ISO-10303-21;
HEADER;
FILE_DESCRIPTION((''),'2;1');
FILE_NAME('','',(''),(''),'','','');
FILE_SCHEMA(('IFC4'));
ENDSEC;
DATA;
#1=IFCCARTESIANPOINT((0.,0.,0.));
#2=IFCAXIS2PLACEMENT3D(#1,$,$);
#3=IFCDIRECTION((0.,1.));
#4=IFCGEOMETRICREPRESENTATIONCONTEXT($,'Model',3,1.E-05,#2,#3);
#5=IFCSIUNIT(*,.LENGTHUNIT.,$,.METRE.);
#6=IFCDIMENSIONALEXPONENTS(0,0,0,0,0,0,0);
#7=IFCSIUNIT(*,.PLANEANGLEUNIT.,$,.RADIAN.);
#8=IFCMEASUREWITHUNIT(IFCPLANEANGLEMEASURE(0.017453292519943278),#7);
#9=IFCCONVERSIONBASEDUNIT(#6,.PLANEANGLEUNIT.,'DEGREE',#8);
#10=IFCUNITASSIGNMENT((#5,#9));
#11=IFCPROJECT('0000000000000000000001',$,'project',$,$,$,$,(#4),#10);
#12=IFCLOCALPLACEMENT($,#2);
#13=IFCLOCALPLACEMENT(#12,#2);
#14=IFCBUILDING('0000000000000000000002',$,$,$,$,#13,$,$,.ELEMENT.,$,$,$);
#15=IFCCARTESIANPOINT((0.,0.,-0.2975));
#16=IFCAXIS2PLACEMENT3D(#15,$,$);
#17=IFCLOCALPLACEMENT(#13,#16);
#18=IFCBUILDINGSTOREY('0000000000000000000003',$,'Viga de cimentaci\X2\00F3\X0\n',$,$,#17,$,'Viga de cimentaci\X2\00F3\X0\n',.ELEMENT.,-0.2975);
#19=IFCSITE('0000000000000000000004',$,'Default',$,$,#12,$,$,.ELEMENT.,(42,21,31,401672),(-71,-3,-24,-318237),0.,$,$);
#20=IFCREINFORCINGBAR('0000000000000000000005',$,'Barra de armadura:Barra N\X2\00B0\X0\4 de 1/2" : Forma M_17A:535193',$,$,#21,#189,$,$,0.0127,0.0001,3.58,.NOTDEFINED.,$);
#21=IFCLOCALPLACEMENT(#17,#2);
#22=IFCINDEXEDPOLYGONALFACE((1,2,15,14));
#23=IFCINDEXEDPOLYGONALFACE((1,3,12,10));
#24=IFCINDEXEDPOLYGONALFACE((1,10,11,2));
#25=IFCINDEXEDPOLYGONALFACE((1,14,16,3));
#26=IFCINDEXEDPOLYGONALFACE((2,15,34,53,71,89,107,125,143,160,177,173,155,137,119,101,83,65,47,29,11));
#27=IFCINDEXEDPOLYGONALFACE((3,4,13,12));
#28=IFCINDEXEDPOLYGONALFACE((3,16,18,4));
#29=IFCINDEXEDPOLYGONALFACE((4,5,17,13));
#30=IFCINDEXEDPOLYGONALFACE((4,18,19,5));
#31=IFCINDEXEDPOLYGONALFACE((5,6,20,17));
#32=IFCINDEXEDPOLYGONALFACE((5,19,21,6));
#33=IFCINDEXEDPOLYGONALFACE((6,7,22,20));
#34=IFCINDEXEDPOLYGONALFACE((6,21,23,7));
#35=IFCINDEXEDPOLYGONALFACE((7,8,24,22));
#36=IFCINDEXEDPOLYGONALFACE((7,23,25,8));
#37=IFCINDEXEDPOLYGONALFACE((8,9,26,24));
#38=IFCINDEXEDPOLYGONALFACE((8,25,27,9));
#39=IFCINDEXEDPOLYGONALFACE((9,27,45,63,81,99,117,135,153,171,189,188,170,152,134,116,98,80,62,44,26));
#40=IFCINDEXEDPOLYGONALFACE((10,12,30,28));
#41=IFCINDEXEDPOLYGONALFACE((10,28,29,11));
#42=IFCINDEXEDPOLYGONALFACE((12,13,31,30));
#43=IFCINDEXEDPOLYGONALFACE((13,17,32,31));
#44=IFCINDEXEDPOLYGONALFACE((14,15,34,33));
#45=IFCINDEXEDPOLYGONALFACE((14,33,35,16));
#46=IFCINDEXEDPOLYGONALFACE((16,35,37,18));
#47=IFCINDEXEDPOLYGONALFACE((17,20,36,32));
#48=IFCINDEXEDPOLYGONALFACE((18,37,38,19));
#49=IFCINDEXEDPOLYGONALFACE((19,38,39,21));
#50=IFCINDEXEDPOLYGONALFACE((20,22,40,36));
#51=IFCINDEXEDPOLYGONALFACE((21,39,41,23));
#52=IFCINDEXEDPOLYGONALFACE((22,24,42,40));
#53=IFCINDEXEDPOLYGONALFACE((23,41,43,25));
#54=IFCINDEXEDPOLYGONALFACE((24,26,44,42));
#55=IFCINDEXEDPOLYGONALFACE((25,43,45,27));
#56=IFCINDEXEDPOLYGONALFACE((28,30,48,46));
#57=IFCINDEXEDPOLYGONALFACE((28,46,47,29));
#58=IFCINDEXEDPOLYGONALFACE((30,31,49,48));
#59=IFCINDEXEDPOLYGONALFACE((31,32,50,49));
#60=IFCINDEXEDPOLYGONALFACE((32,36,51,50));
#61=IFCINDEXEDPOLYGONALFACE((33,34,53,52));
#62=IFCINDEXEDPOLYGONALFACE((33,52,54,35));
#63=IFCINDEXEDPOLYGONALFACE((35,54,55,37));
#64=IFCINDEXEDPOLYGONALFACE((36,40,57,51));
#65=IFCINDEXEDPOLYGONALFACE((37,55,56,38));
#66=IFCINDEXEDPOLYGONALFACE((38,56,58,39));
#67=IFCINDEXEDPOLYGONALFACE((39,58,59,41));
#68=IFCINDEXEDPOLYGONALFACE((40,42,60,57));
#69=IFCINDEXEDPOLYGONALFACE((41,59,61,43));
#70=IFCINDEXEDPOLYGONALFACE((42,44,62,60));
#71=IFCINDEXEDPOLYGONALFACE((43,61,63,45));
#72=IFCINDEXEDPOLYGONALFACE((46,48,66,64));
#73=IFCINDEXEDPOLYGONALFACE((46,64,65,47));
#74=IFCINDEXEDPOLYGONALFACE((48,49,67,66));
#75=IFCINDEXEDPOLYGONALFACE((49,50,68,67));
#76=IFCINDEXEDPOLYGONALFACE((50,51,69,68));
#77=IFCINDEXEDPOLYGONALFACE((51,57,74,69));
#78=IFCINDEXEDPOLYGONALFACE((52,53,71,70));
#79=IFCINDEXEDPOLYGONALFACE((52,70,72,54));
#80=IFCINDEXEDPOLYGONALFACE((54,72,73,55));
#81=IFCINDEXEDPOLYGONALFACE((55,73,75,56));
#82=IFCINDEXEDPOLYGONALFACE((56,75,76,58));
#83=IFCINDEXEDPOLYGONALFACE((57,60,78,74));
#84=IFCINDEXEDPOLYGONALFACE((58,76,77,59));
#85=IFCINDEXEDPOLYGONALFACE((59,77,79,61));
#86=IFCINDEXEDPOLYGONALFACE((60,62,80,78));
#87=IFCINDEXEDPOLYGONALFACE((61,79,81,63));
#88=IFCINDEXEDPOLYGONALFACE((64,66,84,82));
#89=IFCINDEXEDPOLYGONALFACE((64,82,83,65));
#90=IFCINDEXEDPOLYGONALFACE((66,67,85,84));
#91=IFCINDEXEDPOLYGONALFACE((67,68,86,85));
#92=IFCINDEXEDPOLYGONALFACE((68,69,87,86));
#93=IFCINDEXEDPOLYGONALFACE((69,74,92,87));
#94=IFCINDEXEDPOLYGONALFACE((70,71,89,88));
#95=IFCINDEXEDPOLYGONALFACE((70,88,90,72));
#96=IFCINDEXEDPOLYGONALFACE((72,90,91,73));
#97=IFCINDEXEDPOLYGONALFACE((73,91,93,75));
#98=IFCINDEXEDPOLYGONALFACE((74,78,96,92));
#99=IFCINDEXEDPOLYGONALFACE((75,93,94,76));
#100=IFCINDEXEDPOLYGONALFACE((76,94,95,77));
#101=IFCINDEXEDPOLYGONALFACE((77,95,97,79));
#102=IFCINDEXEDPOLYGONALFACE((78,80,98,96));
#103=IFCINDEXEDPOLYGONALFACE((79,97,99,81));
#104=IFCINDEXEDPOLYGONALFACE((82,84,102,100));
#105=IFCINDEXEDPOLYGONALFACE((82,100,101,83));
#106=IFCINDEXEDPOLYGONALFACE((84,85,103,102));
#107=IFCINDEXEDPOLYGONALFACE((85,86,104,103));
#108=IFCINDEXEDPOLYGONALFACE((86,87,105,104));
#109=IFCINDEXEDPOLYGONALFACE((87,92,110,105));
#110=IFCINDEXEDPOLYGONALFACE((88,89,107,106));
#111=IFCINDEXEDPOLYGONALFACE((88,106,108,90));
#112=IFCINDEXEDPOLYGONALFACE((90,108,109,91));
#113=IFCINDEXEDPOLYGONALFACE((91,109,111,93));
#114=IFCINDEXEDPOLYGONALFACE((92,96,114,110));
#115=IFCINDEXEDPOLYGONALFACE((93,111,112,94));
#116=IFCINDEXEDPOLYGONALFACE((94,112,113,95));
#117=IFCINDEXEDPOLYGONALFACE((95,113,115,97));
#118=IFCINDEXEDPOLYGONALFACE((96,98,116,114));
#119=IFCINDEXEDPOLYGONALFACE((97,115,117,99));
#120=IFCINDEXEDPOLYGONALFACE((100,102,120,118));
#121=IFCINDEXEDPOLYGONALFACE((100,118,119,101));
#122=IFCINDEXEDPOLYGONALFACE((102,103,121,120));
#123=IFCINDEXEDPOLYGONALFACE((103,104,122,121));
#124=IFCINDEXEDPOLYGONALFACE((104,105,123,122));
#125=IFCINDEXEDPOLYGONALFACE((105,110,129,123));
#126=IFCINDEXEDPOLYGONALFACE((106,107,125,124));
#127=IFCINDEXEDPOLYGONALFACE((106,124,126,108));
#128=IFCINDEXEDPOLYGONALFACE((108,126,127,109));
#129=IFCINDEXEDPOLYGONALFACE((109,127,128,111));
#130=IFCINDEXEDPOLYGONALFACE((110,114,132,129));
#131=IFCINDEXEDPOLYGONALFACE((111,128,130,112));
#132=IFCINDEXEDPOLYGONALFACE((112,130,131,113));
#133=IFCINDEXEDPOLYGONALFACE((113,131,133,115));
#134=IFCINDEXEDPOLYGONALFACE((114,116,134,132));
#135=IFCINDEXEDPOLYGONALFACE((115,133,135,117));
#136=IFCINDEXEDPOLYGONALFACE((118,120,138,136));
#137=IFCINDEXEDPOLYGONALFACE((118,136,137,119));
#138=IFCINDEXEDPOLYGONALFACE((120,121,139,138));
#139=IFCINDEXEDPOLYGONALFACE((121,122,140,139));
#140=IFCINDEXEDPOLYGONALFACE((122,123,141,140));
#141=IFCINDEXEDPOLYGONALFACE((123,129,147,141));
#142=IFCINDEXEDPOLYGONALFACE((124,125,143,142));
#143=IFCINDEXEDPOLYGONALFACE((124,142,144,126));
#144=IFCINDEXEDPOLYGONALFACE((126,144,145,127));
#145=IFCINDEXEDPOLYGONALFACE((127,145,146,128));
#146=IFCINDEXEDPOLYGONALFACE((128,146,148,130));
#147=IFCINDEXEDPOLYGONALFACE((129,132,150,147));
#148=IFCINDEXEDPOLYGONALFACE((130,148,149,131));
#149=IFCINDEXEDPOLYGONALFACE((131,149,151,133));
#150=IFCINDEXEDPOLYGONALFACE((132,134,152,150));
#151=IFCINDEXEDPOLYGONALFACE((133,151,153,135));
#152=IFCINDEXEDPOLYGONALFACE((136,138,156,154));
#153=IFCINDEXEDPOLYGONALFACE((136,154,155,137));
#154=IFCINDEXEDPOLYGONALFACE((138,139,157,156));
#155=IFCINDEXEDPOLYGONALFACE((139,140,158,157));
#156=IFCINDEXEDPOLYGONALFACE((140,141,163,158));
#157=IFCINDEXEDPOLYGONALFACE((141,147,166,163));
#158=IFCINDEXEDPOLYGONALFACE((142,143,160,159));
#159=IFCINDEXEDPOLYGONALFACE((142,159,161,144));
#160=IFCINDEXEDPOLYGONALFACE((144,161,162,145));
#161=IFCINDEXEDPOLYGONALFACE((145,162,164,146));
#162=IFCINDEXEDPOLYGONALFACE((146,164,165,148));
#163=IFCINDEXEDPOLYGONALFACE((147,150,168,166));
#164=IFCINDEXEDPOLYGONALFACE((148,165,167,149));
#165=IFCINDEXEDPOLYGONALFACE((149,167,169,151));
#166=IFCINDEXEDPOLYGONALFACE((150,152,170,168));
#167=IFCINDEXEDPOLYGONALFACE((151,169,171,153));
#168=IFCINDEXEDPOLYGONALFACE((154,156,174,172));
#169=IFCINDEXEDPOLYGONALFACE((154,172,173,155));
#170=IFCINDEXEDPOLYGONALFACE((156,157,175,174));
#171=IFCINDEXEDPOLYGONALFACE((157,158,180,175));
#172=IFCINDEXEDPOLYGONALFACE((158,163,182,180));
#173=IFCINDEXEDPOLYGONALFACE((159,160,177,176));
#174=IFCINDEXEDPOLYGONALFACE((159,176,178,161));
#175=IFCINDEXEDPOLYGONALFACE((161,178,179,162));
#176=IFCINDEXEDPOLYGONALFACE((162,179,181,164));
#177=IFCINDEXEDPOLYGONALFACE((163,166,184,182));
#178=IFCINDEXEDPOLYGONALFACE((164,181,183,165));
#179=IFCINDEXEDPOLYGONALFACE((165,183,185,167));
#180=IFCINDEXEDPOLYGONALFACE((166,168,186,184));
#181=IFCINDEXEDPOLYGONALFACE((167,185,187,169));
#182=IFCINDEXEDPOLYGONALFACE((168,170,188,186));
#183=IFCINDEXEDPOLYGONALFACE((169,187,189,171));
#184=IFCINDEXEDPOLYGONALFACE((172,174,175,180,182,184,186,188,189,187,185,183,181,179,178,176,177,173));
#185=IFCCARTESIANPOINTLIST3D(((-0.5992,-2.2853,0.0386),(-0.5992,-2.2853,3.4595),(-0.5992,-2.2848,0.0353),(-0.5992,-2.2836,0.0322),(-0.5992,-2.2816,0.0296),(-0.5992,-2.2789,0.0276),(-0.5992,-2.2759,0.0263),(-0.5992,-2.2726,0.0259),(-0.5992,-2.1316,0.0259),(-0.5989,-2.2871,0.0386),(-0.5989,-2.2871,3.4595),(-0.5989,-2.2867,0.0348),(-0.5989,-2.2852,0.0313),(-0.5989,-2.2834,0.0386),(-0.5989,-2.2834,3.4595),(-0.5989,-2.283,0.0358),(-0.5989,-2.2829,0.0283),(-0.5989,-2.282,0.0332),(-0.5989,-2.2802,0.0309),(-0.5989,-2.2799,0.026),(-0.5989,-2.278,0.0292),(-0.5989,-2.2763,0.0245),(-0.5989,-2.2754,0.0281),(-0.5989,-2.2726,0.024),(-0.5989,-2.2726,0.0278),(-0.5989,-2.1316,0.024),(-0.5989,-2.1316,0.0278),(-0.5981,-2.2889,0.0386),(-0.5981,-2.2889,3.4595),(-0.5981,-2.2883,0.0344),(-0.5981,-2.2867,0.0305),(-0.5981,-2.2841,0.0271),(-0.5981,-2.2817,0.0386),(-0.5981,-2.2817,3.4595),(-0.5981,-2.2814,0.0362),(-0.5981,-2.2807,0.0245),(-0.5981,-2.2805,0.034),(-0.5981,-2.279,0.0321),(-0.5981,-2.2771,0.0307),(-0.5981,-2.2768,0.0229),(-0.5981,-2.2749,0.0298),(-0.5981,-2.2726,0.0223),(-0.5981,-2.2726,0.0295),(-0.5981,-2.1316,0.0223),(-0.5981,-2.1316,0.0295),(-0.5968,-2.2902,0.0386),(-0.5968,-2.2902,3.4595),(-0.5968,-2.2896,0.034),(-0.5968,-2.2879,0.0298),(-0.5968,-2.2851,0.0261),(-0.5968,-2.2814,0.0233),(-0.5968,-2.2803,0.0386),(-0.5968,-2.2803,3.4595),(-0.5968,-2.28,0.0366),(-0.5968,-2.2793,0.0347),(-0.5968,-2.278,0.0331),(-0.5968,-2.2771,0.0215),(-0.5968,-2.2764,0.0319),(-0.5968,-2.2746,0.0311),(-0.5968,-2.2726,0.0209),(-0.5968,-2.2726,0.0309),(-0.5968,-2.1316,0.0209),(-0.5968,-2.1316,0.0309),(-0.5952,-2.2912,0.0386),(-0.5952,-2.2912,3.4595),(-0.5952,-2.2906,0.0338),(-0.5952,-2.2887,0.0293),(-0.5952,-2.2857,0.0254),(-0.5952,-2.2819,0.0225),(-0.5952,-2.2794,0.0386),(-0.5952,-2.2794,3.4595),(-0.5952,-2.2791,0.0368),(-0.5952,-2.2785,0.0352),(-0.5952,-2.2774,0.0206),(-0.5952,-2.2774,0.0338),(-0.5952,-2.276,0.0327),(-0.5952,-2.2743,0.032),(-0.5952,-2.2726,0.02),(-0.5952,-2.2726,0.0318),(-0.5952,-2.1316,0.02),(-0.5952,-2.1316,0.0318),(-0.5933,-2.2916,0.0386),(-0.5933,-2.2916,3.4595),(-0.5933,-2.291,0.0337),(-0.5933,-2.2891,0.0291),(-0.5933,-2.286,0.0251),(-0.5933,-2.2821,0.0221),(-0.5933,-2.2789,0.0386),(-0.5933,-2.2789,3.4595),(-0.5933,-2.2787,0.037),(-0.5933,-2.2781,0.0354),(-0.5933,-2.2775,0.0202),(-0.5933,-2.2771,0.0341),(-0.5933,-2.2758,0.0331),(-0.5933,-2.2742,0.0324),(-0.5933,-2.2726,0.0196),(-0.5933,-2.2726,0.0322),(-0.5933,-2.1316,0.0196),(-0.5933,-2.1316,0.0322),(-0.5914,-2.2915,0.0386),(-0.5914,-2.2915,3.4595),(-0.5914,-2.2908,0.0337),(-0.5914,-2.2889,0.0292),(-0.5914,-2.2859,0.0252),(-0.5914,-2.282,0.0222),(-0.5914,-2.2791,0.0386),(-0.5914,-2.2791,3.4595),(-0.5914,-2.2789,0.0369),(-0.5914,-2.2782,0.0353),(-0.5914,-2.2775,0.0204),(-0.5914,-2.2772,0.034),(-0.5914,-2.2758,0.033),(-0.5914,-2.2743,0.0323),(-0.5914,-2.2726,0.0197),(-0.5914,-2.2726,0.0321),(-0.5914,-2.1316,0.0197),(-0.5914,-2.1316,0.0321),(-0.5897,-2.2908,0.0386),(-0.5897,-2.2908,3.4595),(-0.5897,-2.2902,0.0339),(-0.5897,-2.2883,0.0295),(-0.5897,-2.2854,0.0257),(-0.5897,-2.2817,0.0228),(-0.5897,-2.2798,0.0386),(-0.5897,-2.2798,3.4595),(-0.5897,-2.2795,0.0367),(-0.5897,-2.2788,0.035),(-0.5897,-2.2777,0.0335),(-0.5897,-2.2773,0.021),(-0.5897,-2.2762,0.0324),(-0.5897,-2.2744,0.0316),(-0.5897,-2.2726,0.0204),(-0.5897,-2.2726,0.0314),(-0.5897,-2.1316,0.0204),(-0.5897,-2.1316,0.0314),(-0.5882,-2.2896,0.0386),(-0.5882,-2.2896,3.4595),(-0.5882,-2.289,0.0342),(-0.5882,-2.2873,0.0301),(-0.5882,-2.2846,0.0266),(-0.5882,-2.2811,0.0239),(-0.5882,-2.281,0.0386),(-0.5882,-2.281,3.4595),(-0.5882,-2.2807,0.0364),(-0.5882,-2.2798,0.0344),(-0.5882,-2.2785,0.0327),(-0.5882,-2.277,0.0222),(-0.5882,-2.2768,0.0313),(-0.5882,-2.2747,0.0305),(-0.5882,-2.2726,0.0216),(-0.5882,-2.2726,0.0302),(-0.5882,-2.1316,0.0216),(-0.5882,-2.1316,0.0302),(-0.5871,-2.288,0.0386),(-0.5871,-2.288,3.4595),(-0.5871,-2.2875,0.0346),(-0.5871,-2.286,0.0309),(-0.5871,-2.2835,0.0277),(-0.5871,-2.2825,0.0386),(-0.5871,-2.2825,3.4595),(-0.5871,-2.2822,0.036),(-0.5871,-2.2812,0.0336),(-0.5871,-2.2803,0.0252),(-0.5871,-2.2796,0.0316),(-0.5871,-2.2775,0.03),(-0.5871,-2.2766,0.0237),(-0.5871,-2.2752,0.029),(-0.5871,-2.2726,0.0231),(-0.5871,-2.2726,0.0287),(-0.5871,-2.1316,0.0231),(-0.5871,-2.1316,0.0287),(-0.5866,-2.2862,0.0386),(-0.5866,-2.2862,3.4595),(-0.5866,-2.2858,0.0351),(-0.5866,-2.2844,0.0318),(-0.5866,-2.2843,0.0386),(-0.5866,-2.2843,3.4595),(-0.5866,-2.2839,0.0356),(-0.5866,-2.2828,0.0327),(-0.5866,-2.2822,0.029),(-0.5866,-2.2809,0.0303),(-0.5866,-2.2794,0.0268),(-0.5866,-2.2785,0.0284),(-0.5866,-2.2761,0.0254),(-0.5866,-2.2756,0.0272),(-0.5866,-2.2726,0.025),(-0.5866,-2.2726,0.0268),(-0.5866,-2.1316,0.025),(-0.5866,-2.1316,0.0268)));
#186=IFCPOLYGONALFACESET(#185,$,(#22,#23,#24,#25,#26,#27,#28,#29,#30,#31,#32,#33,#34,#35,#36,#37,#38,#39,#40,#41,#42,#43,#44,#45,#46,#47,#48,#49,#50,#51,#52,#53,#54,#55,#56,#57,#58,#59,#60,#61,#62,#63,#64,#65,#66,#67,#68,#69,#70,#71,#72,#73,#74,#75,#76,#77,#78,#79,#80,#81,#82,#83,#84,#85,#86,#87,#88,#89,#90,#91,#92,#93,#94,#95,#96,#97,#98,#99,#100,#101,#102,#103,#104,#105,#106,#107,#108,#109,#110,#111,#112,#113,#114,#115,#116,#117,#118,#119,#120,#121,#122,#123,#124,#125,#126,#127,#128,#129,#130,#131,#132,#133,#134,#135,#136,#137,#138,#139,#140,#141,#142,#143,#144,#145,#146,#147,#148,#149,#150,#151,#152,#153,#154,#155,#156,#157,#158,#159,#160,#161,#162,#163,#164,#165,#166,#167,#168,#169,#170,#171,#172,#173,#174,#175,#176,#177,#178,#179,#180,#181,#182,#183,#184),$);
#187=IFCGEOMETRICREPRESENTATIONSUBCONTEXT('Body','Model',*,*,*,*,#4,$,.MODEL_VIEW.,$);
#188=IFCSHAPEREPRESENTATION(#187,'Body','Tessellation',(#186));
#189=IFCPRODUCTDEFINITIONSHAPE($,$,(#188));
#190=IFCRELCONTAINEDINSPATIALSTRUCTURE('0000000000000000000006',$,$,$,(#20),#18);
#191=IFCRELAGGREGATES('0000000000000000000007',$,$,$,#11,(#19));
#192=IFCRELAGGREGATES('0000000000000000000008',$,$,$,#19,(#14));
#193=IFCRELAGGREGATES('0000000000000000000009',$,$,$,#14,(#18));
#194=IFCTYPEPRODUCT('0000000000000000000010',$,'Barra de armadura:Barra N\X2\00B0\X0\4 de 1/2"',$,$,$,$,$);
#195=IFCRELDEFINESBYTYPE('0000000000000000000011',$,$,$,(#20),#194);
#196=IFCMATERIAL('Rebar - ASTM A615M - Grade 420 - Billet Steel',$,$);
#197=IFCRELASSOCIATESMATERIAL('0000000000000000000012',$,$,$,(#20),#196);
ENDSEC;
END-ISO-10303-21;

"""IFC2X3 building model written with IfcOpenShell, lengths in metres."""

from ifc_helpers import new_model, entity, si_unit, converted_unit, direction, frame, origin, place, context, subcontext, project, spatial, material, type_object, element, save


model = new_model("IFC2X3")

# Units and contexts
model_context = context("Model", 3, precision=1e-05, world=origin(), true_north=direction((0.0, 1.0)))
body_context = subcontext(model_context, "Body", "Model", "MODEL_VIEW")
ifc_project = project(units=[si_unit("LENGTHUNIT", "METRE"), converted_unit("PLANEANGLEUNIT", "DEGREE", entity("IfcPlaneAngleMeasure", 0.017453292519943278), si_unit("PLANEANGLEUNIT", "RADIAN"), dimensions=[0, 0, 0, 0, 0, 0, 0])], contexts=[model_context])

# Site, building, storey
site_placement = place(None, origin())
site = spatial("IfcSite", under=ifc_project, at=site_placement, Name="Default", CompositionType="ELEMENT", RefLatitude=(42, 21, 31, 401672), RefLongitude=(-71, -3, -24, -318237), RefElevation=0.0)
building_placement = place(site_placement, origin())
building = spatial("IfcBuilding", under=site, at=building_placement, CompositionType="ELEMENT")
storey_placement = place(building_placement, frame((0.0, 0.0, -0.2975)))
storey = spatial("IfcBuildingStorey", under=building, at=storey_placement, Name="Viga de cimentación", LongName="Viga de cimentación", CompositionType="ELEMENT", Elevation=-0.2975)

# Reinforcing bar
ifc_material = material(Name="Rebar - ASTM A615M - Grade 420 - Billet Steel")
type_product_1 = type_object("IfcTypeProduct", Name="Barra de armadura:Barra N°4 de 1/2\"")
reinforcing_bar_1_placement = place(storey_placement, origin())
element("IfcReinforcingBar", 1, at=reinforcing_bar_1_placement, inside=storey, type_object=type_product_1, material=ifc_material, Name="Barra de armadura:Barra N°4 de 1/2\" : Forma M_17A:535193", BarLength=3.58, BarRole="NOTDEFINED", CrossSectionArea=0.0001, NominalDiameter=0.0127, context=body_context, shape_type="AdvancedSweptSolid", body=[
    entity("IfcSweptDiskSolid", entity("IfcCompositeCurve", [entity("IfcCompositeCurveSegment", "CONTINUOUS", True, entity("IfcPolyline", [entity("IfcCartesianPoint", [-0.5929, -2.2853, 3.4595]), entity("IfcCartesianPoint", [-0.5929, -2.2853, 0.0386])])), entity("IfcCompositeCurveSegment", "CONTINUOUS", True, entity("IfcTrimmedCurve", entity("IfcCircle", entity("IfcAxis2Placement3D", entity("IfcCartesianPoint", [-0.5929, -2.2726, 0.0386]), entity("IfcDirection", [1.0, 0.0, 0.0]), entity("IfcDirection", [0.0, 0.0, -1.0])), 0.0127), [entity("IfcParameterValue", 270.0)], [entity("IfcParameterValue", 360.0)], True, "PARAMETER")), entity("IfcCompositeCurveSegment", "CONTINUOUS", True, entity("IfcPolyline", [entity("IfcCartesianPoint", [-0.5929, -2.2726, 0.0259]), entity("IfcCartesianPoint", [-0.5929, -2.1316, 0.0259])]))], False), 0.0063, None, 0.0, 92.0),
])

save(model, "model.ifc")
